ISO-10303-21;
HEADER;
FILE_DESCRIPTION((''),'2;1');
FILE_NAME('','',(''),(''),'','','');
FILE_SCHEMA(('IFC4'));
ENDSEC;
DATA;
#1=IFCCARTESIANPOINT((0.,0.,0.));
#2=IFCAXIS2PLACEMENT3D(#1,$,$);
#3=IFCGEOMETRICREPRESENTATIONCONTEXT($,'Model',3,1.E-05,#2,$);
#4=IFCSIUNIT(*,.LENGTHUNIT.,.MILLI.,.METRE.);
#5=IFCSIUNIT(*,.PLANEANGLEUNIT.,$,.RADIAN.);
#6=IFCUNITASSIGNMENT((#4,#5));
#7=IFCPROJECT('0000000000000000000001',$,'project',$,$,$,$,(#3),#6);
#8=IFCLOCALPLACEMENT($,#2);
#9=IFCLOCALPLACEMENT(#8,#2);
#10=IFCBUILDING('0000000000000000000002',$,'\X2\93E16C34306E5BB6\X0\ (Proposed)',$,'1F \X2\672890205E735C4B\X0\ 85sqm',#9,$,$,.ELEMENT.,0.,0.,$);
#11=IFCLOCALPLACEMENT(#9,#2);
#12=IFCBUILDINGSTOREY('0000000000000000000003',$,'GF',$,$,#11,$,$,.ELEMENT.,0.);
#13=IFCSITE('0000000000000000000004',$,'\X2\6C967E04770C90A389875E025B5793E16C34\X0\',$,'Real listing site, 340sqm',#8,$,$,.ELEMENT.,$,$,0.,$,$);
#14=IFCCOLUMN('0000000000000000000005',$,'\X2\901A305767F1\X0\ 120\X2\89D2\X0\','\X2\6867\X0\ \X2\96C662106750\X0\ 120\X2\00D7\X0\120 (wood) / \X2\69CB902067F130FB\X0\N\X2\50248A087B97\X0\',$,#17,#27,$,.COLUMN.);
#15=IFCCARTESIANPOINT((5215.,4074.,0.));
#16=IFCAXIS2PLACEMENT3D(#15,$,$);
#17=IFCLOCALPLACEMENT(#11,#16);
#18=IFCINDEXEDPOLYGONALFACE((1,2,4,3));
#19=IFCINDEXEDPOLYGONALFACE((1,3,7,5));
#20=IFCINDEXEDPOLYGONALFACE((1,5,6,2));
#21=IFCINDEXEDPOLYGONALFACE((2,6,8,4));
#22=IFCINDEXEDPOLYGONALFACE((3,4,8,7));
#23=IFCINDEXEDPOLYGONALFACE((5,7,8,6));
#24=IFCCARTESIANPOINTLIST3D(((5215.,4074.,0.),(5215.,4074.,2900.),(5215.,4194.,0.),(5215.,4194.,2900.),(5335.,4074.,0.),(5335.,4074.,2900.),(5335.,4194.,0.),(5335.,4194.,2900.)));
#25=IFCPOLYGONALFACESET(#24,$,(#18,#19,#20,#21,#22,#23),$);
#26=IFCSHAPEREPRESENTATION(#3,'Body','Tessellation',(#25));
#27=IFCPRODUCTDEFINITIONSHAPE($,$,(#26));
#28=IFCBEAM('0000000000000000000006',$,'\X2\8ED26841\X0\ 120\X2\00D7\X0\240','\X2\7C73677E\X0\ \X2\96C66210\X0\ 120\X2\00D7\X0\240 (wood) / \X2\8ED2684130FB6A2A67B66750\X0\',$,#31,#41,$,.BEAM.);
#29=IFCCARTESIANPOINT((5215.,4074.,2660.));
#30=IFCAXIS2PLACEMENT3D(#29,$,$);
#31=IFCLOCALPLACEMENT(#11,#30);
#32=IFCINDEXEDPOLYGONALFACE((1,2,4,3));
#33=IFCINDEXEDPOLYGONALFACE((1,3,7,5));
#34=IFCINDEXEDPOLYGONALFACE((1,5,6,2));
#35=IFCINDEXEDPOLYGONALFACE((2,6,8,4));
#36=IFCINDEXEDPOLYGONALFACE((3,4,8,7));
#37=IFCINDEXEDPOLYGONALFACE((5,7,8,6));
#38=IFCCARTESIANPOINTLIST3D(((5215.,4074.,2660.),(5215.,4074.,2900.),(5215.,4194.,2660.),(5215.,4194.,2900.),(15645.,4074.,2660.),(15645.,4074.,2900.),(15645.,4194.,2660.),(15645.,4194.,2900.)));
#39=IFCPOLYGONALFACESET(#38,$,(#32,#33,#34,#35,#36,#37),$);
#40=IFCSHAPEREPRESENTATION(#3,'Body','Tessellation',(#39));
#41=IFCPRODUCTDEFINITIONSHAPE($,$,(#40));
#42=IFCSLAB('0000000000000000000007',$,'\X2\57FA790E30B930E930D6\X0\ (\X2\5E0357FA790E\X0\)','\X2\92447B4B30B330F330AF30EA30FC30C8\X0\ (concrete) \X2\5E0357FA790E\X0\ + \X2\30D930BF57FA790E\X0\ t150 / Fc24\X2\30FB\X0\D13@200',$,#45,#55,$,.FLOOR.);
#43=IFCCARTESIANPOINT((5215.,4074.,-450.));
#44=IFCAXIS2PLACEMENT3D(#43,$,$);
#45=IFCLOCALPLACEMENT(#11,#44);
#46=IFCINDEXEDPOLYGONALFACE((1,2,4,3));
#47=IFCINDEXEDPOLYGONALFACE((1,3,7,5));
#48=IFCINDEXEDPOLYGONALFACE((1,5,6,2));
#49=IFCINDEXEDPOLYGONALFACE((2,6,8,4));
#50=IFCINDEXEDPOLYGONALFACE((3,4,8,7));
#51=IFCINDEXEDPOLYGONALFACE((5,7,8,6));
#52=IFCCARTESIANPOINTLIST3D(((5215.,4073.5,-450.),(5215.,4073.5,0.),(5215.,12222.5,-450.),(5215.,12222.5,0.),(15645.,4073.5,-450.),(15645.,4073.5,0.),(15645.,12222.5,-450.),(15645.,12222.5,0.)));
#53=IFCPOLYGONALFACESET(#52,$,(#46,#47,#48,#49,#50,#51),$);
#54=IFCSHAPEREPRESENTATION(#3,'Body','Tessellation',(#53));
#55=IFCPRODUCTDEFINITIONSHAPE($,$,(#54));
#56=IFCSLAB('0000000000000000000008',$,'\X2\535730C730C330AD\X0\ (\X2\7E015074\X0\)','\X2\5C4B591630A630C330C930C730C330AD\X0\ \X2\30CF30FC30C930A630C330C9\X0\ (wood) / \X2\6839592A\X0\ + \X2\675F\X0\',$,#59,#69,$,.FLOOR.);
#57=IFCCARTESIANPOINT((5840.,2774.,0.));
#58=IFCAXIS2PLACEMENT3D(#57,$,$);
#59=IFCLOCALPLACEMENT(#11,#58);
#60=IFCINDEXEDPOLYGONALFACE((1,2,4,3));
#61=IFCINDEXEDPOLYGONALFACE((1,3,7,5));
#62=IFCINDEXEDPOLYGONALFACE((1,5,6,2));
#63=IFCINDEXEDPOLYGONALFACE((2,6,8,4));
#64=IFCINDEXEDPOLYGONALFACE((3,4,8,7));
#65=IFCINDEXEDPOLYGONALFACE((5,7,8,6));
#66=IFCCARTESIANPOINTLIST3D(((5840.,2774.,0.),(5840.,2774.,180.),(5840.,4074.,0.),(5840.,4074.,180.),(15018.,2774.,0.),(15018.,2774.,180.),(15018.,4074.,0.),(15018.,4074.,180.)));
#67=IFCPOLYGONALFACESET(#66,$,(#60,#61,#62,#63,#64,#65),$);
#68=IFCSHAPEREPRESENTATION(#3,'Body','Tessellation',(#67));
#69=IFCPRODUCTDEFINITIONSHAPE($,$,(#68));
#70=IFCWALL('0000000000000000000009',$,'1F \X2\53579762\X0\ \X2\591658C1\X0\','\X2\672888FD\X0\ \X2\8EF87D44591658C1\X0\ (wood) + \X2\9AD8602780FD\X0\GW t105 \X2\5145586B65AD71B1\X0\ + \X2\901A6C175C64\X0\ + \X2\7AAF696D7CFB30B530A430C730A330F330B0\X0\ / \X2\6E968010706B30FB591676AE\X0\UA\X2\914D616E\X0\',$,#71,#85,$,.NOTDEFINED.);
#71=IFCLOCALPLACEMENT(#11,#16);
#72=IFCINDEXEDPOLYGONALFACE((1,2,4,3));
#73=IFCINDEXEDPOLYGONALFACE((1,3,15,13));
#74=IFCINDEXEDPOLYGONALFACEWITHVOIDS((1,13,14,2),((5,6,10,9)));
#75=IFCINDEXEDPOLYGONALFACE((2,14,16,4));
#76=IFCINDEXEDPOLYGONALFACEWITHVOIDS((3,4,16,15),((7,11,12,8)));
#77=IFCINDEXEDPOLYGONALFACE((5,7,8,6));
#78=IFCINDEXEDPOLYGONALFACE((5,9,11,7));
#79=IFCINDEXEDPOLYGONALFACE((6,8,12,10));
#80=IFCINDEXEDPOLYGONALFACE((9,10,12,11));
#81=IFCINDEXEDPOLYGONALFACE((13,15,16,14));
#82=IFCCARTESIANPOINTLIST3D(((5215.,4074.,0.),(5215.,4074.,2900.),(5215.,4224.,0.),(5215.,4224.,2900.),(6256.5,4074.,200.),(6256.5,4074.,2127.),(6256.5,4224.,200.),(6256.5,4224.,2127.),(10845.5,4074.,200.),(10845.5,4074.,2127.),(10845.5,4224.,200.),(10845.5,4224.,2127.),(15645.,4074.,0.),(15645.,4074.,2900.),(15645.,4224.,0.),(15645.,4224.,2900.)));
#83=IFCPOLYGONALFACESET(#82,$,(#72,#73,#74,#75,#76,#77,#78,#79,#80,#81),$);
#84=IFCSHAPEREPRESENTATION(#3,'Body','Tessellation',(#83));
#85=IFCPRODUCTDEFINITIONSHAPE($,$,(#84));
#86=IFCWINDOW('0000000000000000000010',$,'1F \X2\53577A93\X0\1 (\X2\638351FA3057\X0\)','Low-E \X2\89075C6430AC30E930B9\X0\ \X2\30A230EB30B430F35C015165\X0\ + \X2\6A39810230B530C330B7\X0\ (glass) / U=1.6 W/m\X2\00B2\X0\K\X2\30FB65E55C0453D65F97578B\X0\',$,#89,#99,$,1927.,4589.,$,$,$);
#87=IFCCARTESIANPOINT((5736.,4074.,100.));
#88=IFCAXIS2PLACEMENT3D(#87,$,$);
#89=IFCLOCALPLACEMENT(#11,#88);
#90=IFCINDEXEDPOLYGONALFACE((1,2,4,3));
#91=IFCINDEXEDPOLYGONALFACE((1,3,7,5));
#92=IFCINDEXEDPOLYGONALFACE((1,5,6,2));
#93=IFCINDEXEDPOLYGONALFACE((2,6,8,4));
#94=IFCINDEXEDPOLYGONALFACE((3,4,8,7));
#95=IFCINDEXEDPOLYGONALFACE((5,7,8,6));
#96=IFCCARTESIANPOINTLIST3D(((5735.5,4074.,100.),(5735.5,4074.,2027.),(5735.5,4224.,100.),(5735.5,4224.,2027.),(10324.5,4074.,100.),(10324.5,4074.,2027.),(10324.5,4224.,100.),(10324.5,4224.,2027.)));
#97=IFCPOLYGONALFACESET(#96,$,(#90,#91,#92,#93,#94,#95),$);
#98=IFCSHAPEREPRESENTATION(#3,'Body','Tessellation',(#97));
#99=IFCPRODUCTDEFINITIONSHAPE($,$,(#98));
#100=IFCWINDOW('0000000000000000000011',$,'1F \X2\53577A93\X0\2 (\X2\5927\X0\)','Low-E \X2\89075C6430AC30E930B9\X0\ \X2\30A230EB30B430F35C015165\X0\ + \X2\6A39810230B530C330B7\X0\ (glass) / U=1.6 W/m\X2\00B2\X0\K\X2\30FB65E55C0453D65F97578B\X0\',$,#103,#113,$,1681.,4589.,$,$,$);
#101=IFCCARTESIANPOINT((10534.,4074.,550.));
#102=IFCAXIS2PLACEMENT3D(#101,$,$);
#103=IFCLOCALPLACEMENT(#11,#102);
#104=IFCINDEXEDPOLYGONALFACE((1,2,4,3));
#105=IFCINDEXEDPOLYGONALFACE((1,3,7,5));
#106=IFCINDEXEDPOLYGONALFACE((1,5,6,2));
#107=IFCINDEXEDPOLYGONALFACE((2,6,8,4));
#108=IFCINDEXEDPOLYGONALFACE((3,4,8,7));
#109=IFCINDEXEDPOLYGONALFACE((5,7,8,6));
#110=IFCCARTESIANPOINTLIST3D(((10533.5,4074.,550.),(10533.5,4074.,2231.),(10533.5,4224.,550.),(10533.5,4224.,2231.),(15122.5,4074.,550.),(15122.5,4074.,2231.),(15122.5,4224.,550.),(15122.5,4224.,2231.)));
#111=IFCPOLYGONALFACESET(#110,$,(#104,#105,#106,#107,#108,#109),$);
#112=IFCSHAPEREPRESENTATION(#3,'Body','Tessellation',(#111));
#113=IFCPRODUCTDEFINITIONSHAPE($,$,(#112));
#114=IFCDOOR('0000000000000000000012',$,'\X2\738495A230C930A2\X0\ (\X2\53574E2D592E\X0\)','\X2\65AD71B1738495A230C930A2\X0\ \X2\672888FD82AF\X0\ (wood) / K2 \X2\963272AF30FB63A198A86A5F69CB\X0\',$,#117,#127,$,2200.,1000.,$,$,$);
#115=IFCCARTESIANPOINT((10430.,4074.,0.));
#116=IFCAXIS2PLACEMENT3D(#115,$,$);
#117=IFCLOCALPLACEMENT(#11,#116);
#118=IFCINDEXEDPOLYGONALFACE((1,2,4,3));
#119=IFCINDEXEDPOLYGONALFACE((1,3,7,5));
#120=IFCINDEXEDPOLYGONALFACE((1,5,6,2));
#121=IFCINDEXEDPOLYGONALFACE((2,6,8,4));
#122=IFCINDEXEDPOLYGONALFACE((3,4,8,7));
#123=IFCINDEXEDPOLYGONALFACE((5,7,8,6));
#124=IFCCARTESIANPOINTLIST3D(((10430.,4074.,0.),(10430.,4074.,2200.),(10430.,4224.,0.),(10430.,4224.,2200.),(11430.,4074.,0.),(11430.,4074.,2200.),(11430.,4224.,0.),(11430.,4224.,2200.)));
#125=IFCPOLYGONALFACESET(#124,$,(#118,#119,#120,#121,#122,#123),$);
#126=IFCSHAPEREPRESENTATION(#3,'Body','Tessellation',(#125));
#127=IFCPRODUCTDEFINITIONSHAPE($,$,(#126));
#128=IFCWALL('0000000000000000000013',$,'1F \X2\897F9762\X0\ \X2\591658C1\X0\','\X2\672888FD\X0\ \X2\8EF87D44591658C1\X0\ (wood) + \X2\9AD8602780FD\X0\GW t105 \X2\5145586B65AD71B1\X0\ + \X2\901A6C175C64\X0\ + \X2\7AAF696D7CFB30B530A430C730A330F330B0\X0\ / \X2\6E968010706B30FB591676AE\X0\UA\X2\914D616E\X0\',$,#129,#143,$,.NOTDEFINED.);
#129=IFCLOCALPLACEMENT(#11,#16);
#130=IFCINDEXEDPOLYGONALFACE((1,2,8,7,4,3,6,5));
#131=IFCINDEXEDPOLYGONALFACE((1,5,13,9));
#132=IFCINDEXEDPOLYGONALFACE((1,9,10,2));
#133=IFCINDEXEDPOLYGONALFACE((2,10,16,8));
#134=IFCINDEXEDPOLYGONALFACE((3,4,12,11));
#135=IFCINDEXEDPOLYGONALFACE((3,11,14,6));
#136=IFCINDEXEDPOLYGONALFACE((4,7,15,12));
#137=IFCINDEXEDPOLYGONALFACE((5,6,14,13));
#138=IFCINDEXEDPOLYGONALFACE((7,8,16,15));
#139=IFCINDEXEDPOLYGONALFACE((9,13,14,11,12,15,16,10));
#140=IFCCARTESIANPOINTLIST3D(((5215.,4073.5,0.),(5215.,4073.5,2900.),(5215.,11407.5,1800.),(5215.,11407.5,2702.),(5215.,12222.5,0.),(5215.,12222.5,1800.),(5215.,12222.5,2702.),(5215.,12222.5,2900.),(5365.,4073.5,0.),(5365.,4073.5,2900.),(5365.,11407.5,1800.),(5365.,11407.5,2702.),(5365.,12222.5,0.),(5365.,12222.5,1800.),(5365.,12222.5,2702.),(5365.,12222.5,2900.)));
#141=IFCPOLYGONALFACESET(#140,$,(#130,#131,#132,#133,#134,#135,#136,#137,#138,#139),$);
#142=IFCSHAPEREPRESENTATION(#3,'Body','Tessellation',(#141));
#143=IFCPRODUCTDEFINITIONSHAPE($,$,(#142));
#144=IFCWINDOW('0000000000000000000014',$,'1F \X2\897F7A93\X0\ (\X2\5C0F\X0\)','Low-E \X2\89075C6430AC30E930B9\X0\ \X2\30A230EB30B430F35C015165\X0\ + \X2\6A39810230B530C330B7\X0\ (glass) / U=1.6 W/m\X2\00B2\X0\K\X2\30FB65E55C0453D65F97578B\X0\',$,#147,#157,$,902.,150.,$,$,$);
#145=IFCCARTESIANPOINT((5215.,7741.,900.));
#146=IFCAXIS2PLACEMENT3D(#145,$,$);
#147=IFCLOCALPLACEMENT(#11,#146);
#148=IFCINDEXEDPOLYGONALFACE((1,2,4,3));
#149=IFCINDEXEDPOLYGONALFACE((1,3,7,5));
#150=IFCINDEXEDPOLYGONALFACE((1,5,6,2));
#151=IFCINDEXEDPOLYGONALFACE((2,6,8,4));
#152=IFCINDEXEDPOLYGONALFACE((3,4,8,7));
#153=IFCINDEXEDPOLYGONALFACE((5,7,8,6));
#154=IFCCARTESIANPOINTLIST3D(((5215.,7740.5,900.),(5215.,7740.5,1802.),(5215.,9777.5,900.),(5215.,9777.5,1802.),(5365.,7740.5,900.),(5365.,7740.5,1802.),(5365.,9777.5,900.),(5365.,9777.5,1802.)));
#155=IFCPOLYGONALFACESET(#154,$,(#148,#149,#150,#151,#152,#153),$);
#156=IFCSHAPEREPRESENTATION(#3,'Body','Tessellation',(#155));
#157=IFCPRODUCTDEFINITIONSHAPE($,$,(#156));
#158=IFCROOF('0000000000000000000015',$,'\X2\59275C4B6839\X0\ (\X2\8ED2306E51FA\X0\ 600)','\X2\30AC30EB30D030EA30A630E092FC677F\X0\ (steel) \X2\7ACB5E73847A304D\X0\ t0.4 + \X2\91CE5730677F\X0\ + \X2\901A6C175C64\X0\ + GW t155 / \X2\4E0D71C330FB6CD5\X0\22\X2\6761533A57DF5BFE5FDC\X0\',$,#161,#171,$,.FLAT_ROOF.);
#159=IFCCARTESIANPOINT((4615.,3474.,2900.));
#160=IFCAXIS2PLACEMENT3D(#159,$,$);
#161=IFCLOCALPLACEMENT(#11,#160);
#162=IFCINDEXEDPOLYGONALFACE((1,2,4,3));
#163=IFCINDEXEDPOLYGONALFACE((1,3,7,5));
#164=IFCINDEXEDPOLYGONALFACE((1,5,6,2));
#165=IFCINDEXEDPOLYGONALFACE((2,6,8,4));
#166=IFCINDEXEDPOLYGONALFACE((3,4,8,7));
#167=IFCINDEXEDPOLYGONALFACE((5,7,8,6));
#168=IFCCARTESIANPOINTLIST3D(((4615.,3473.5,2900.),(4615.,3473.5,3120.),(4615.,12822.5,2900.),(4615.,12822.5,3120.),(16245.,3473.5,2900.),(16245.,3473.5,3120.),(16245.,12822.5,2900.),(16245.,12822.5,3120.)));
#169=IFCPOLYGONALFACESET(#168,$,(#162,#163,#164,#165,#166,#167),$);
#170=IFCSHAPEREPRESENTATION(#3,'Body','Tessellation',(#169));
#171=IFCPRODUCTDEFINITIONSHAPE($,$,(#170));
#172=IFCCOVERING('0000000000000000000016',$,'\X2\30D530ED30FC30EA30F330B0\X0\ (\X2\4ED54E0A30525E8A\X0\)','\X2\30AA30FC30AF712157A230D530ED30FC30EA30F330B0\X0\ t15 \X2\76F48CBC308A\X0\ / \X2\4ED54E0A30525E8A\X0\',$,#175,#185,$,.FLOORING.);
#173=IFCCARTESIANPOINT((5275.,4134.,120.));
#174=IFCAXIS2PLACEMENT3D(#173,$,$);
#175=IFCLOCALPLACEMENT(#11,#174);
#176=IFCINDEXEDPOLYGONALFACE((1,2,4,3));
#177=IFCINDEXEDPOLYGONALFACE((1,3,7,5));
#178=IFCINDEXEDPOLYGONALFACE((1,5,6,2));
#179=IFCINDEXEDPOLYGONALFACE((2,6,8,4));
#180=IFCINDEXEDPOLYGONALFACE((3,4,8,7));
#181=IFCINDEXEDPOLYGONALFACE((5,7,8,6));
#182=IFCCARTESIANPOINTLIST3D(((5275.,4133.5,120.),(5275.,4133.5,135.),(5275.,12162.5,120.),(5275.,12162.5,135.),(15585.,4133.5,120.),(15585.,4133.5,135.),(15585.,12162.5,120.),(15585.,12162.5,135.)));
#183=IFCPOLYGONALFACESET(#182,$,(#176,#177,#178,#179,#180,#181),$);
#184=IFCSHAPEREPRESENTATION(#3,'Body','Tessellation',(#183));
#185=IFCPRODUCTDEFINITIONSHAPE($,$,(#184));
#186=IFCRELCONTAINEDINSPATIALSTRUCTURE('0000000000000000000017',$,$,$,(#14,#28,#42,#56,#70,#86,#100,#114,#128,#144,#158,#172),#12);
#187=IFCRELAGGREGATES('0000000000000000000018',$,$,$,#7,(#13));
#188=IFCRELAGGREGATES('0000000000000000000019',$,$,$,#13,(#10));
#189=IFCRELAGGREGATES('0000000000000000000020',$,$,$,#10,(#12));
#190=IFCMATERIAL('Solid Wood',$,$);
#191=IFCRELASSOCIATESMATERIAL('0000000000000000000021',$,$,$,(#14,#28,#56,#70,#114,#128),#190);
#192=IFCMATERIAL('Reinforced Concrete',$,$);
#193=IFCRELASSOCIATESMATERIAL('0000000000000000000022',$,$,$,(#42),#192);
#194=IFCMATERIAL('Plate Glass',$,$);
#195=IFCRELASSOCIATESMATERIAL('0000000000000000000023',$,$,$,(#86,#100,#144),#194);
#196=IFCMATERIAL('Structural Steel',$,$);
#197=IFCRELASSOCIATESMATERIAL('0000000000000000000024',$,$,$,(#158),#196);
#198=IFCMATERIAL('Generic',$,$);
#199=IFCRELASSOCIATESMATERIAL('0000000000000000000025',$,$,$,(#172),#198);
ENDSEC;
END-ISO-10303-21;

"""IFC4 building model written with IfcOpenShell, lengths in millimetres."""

from ifc_helpers import new_model, si_unit, frame, frame_2d, origin, place, context, project, spatial, rectangle, extrude, material, element, fill, save


model = new_model("IFC4")

# Units and contexts
model_context = context("Model", 3, precision=1e-05, world=origin())
ifc_project = project(units=[si_unit("LENGTHUNIT", "METRE", prefix="MILLI"), si_unit("PLANEANGLEUNIT", "RADIAN")], contexts=[model_context])

# Site, building, storey
site_placement = place(None, origin())
site = spatial("IfcSite", under=ifc_project, at=site_placement, Name="沖縄県那覇市字鏡水", ObjectType="Real listing site, 340sqm", CompositionType="ELEMENT", RefElevation=0.0)
building_placement = place(site_placement, origin())
building = spatial("IfcBuilding", under=site, at=building_placement, Name="鏡水の家 (Proposed)", ObjectType="1F 木造平屋 85sqm", CompositionType="ELEMENT", ElevationOfRefHeight=0.0, ElevationOfTerrain=0.0)
storey_placement = place(building_placement, origin())
storey = spatial("IfcBuildingStorey", under=building, at=storey_placement, Name="GF", CompositionType="ELEMENT", Elevation=0.0)

# Column
ifc_material_1 = material(Name="Solid Wood")
column_1_placement = place(storey_placement, frame((5215.0, 4074.0, 0.0)))
element("IfcColumn", 1, at=column_1_placement, inside=storey, material=ifc_material_1, Name="通し柱 120角", Description="桧 集成材 120×120 (wood) / 構造柱・N値計算", PredefinedType="COLUMN", context=model_context, shape_type="SweptSolid", body=[
    extrude(rectangle(XDim=120.0, YDim=120.0, at=frame_2d((60.0, 60.0))), frame((5215.0, 4074.0, 0.0)), (0.0, 0.0, 1.0), 2900.0),
])

# Beam
beam_1_placement = place(storey_placement, frame((5215.0, 4074.0, 2660.0)))
element("IfcBeam", 2, at=beam_1_placement, inside=storey, material=ifc_material_1, Name="軒桁 120×240", Description="米松 集成 120×240 (wood) / 軒桁・横架材", PredefinedType="BEAM", context=model_context, shape_type="SweptSolid", body=[
    extrude(rectangle(XDim=10430.0, YDim=120.0, at=frame_2d((5215.0, 60.0))), frame((5215.0, 4074.0, 2660.0)), (0.0, 0.0, 1.0), 240.0),
])

# Slabs
ifc_material_2 = material(Name="Reinforced Concrete")
slab_1_placement = place(storey_placement, frame((5215.0, 4074.0, -450.0)))
element("IfcSlab", 3, at=slab_1_placement, inside=storey, material=ifc_material_2, Name="基礎スラブ (布基礎)", Description="鉄筋コンクリート (concrete) 布基礎 + ベタ基礎 t150 / Fc24・D13@200", PredefinedType="FLOOR", context=model_context, shape_type="SweptSolid", body=[
    extrude(rectangle(XDim=10430.0, YDim=8149.0, at=frame_2d((5215.0, 4074.0))), frame((5215.0, 4074.0, -450.0)), (0.0, 0.0, 1.0), 450.0),
])
slab_2_placement = place(storey_placement, frame((5840.0, 2774.0, 0.0)))
element("IfcSlab", 4, at=slab_2_placement, inside=storey, material=ifc_material_1, Name="南デッキ (縁側)", Description="屋外ウッドデッキ ハードウッド (wood) / 根太 + 束", PredefinedType="FLOOR", context=model_context, shape_type="SweptSolid", body=[
    extrude(rectangle(XDim=9178.0, YDim=1300.0, at=frame_2d((4589.0, 650.0))), frame((5840.0, 2774.0, 0.0)), (0.0, 0.0, 1.0), 180.0),
])

# Wall, openings, windows, door
wall_1_placement = place(storey_placement, frame((5215.0, 4074.0, 0.0)))
wall_1 = element("IfcWall", 5, at=wall_1_placement, inside=storey, material=ifc_material_1, Name="1F 南面 外壁", Description="木製 軸組外壁 (wood) + 高性能GW t105 充填断熱 + 通気層 + 窯業系サイディング / 準耐火・外皮UA配慮", PredefinedType="NOTDEFINED", context=model_context, shape_type="SweptSolid", body=[
    extrude(rectangle(XDim=10430.0, YDim=150.0, at=frame_2d((5215.0, 75.0))), frame((5215.0, 4074.0, 0.0)), (0.0, 0.0, 1.0), 2900.0),
])
opening_1_placement = place(storey_placement, frame((5736.0, 4074.0, 100.0)))
opening_1 = element("IfcOpeningElement", 6, at=opening_1_placement, cuts=wall_1, PredefinedType="NOTDEFINED", context=model_context, shape_type="SweptSolid", body=[
    extrude(rectangle(XDim=4589.0, YDim=150.0, at=frame_2d((2294.0, 75.0))), frame((5736.0, 4074.0, 100.0)), (0.0, 0.0, 1.0), 1927.0),
])
opening_2_placement = place(storey_placement, frame((10534.0, 4074.0, 550.0)))
opening_2 = element("IfcOpeningElement", 7, at=opening_2_placement, cuts=wall_1, PredefinedType="NOTDEFINED", context=model_context, shape_type="SweptSolid", body=[
    extrude(rectangle(XDim=4589.0, YDim=150.0, at=frame_2d((2294.0, 75.0))), frame((10534.0, 4074.0, 550.0)), (0.0, 0.0, 1.0), 1681.0),
])
opening_3_placement = place(storey_placement, frame((10430.0, 4074.0, 0.0)))
opening_3 = element("IfcOpeningElement", 8, at=opening_3_placement, cuts=wall_1, PredefinedType="NOTDEFINED", context=model_context, shape_type="SweptSolid", body=[
    extrude(rectangle(XDim=1000.0, YDim=150.0, at=frame_2d((500.0, 75.0))), frame((10430.0, 4074.0, 0.0)), (0.0, 0.0, 1.0), 2200.0),
])
ifc_material_3 = material(Name="Plate Glass")
window_1_placement = place(storey_placement, frame((5736.0, 4074.0, 100.0)))
window_1 = element("IfcWindow", 9, at=window_1_placement, inside=storey, material=ifc_material_3, Name="1F 南窓1 (掃出し)", Description="Low-E 複層ガラス アルゴン封入 + 樹脂サッシ (glass) / U=1.6 W/m²K・日射取得型", OverallHeight=1927.0, OverallWidth=4589.0, context=model_context, shape_type="SweptSolid", body=[
    extrude(rectangle(XDim=4589.0, YDim=150.0, at=frame_2d((2294.0, 75.0))), frame((5736.0, 4074.0, 100.0)), (0.0, 0.0, 1.0), 1927.0),
])
fill(opening_1, window_1)
window_2_placement = place(storey_placement, frame((10534.0, 4074.0, 550.0)))
window_2 = element("IfcWindow", 10, at=window_2_placement, inside=storey, material=ifc_material_3, Name="1F 南窓2 (大)", Description="Low-E 複層ガラス アルゴン封入 + 樹脂サッシ (glass) / U=1.6 W/m²K・日射取得型", OverallHeight=1681.0, OverallWidth=4589.0, context=model_context, shape_type="SweptSolid", body=[
    extrude(rectangle(XDim=4589.0, YDim=150.0, at=frame_2d((2294.0, 75.0))), frame((10534.0, 4074.0, 550.0)), (0.0, 0.0, 1.0), 1681.0),
])
fill(opening_2, window_2)
door_placement = place(storey_placement, frame((10430.0, 4074.0, 0.0)))
door = element("IfcDoor", 11, at=door_placement, inside=storey, material=ifc_material_1, Name="玄関ドア (南中央)", Description="断熱玄関ドア 木製芯 (wood) / K2 防犯・採風機構", OverallHeight=2200.0, OverallWidth=1000.0, context=model_context, shape_type="SweptSolid", body=[
    extrude(rectangle(XDim=1000.0, YDim=150.0, at=frame_2d((500.0, 75.0))), frame((10430.0, 4074.0, 0.0)), (0.0, 0.0, 1.0), 2200.0),
])
fill(opening_3, door)

# Wall, opening, window
wall_2_placement = place(storey_placement, frame((5215.0, 4074.0, 0.0)))
wall_2 = element("IfcWall", 12, at=wall_2_placement, inside=storey, material=ifc_material_1, Name="1F 西面 外壁", Description="木製 軸組外壁 (wood) + 高性能GW t105 充填断熱 + 通気層 + 窯業系サイディング / 準耐火・外皮UA配慮", PredefinedType="NOTDEFINED", context=model_context, shape_type="SweptSolid", body=[
    extrude(rectangle(XDim=150.0, YDim=8149.0, at=frame_2d((75.0, 4074.0))), frame((5215.0, 4074.0, 0.0)), (0.0, 0.0, 1.0), 2900.0),
])
opening_4_placement = place(storey_placement, frame((5215.0, 7741.0, 900.0)))
opening_4 = element("IfcOpeningElement", 13, at=opening_4_placement, cuts=wall_2, PredefinedType="NOTDEFINED", context=model_context, shape_type="SweptSolid", body=[
    extrude(rectangle(XDim=150.0, YDim=2037.0, at=frame_2d((75.0, 1018.0))), frame((5215.0, 7741.0, 900.0)), (0.0, 0.0, 1.0), 902.0),
])
window_3_placement = place(storey_placement, frame((5215.0, 7741.0, 900.0)))
window_3 = element("IfcWindow", 14, at=window_3_placement, inside=storey, material=ifc_material_3, Name="1F 西窓 (小)", Description="Low-E 複層ガラス アルゴン封入 + 樹脂サッシ (glass) / U=1.6 W/m²K・日射取得型", OverallHeight=902.0, OverallWidth=150.0, context=model_context, shape_type="SweptSolid", body=[
    extrude(rectangle(XDim=150.0, YDim=2037.0, at=frame_2d((75.0, 1018.0))), frame((5215.0, 7741.0, 900.0)), (0.0, 0.0, 1.0), 902.0),
])
fill(opening_4, window_3)

# Roof
ifc_material_4 = material(Name="Structural Steel")
roof_placement = place(storey_placement, frame((4615.0, 3474.0, 2900.0)))
element("IfcRoof", 15, at=roof_placement, inside=storey, material=ifc_material_4, Name="大屋根 (軒の出 600)", Description="ガルバリウム鋼板 (steel) 立平葺き t0.4 + 野地板 + 通気層 + GW t155 / 不燃・法22条区域対応", PredefinedType="FLAT_ROOF", context=model_context, shape_type="SweptSolid", body=[
    extrude(rectangle(XDim=11630.0, YDim=9349.0, at=frame_2d((5815.0, 4674.0))), frame((4615.0, 3474.0, 2900.0)), (0.0, 0.0, 1.0), 220.0),
])

# Covering
ifc_material_5 = material(Name="Generic")
covering_1_placement = place(storey_placement, frame((5275.0, 4134.0, 120.0)))
element("IfcCovering", 16, at=covering_1_placement, inside=storey, material=ifc_material_5, Name="フローリング (仕上げ床)", Description="オーク無垢フローリング t15 直貼り / 仕上げ床", PredefinedType="FLOORING", context=model_context, shape_type="SweptSolid", body=[
    extrude(rectangle(XDim=10310.0, YDim=8029.0, at=frame_2d((5155.0, 4014.0))), frame((5275.0, 4134.0, 120.0)), (0.0, 0.0, 1.0), 15.0),
])

save(model, "model.ifc")
